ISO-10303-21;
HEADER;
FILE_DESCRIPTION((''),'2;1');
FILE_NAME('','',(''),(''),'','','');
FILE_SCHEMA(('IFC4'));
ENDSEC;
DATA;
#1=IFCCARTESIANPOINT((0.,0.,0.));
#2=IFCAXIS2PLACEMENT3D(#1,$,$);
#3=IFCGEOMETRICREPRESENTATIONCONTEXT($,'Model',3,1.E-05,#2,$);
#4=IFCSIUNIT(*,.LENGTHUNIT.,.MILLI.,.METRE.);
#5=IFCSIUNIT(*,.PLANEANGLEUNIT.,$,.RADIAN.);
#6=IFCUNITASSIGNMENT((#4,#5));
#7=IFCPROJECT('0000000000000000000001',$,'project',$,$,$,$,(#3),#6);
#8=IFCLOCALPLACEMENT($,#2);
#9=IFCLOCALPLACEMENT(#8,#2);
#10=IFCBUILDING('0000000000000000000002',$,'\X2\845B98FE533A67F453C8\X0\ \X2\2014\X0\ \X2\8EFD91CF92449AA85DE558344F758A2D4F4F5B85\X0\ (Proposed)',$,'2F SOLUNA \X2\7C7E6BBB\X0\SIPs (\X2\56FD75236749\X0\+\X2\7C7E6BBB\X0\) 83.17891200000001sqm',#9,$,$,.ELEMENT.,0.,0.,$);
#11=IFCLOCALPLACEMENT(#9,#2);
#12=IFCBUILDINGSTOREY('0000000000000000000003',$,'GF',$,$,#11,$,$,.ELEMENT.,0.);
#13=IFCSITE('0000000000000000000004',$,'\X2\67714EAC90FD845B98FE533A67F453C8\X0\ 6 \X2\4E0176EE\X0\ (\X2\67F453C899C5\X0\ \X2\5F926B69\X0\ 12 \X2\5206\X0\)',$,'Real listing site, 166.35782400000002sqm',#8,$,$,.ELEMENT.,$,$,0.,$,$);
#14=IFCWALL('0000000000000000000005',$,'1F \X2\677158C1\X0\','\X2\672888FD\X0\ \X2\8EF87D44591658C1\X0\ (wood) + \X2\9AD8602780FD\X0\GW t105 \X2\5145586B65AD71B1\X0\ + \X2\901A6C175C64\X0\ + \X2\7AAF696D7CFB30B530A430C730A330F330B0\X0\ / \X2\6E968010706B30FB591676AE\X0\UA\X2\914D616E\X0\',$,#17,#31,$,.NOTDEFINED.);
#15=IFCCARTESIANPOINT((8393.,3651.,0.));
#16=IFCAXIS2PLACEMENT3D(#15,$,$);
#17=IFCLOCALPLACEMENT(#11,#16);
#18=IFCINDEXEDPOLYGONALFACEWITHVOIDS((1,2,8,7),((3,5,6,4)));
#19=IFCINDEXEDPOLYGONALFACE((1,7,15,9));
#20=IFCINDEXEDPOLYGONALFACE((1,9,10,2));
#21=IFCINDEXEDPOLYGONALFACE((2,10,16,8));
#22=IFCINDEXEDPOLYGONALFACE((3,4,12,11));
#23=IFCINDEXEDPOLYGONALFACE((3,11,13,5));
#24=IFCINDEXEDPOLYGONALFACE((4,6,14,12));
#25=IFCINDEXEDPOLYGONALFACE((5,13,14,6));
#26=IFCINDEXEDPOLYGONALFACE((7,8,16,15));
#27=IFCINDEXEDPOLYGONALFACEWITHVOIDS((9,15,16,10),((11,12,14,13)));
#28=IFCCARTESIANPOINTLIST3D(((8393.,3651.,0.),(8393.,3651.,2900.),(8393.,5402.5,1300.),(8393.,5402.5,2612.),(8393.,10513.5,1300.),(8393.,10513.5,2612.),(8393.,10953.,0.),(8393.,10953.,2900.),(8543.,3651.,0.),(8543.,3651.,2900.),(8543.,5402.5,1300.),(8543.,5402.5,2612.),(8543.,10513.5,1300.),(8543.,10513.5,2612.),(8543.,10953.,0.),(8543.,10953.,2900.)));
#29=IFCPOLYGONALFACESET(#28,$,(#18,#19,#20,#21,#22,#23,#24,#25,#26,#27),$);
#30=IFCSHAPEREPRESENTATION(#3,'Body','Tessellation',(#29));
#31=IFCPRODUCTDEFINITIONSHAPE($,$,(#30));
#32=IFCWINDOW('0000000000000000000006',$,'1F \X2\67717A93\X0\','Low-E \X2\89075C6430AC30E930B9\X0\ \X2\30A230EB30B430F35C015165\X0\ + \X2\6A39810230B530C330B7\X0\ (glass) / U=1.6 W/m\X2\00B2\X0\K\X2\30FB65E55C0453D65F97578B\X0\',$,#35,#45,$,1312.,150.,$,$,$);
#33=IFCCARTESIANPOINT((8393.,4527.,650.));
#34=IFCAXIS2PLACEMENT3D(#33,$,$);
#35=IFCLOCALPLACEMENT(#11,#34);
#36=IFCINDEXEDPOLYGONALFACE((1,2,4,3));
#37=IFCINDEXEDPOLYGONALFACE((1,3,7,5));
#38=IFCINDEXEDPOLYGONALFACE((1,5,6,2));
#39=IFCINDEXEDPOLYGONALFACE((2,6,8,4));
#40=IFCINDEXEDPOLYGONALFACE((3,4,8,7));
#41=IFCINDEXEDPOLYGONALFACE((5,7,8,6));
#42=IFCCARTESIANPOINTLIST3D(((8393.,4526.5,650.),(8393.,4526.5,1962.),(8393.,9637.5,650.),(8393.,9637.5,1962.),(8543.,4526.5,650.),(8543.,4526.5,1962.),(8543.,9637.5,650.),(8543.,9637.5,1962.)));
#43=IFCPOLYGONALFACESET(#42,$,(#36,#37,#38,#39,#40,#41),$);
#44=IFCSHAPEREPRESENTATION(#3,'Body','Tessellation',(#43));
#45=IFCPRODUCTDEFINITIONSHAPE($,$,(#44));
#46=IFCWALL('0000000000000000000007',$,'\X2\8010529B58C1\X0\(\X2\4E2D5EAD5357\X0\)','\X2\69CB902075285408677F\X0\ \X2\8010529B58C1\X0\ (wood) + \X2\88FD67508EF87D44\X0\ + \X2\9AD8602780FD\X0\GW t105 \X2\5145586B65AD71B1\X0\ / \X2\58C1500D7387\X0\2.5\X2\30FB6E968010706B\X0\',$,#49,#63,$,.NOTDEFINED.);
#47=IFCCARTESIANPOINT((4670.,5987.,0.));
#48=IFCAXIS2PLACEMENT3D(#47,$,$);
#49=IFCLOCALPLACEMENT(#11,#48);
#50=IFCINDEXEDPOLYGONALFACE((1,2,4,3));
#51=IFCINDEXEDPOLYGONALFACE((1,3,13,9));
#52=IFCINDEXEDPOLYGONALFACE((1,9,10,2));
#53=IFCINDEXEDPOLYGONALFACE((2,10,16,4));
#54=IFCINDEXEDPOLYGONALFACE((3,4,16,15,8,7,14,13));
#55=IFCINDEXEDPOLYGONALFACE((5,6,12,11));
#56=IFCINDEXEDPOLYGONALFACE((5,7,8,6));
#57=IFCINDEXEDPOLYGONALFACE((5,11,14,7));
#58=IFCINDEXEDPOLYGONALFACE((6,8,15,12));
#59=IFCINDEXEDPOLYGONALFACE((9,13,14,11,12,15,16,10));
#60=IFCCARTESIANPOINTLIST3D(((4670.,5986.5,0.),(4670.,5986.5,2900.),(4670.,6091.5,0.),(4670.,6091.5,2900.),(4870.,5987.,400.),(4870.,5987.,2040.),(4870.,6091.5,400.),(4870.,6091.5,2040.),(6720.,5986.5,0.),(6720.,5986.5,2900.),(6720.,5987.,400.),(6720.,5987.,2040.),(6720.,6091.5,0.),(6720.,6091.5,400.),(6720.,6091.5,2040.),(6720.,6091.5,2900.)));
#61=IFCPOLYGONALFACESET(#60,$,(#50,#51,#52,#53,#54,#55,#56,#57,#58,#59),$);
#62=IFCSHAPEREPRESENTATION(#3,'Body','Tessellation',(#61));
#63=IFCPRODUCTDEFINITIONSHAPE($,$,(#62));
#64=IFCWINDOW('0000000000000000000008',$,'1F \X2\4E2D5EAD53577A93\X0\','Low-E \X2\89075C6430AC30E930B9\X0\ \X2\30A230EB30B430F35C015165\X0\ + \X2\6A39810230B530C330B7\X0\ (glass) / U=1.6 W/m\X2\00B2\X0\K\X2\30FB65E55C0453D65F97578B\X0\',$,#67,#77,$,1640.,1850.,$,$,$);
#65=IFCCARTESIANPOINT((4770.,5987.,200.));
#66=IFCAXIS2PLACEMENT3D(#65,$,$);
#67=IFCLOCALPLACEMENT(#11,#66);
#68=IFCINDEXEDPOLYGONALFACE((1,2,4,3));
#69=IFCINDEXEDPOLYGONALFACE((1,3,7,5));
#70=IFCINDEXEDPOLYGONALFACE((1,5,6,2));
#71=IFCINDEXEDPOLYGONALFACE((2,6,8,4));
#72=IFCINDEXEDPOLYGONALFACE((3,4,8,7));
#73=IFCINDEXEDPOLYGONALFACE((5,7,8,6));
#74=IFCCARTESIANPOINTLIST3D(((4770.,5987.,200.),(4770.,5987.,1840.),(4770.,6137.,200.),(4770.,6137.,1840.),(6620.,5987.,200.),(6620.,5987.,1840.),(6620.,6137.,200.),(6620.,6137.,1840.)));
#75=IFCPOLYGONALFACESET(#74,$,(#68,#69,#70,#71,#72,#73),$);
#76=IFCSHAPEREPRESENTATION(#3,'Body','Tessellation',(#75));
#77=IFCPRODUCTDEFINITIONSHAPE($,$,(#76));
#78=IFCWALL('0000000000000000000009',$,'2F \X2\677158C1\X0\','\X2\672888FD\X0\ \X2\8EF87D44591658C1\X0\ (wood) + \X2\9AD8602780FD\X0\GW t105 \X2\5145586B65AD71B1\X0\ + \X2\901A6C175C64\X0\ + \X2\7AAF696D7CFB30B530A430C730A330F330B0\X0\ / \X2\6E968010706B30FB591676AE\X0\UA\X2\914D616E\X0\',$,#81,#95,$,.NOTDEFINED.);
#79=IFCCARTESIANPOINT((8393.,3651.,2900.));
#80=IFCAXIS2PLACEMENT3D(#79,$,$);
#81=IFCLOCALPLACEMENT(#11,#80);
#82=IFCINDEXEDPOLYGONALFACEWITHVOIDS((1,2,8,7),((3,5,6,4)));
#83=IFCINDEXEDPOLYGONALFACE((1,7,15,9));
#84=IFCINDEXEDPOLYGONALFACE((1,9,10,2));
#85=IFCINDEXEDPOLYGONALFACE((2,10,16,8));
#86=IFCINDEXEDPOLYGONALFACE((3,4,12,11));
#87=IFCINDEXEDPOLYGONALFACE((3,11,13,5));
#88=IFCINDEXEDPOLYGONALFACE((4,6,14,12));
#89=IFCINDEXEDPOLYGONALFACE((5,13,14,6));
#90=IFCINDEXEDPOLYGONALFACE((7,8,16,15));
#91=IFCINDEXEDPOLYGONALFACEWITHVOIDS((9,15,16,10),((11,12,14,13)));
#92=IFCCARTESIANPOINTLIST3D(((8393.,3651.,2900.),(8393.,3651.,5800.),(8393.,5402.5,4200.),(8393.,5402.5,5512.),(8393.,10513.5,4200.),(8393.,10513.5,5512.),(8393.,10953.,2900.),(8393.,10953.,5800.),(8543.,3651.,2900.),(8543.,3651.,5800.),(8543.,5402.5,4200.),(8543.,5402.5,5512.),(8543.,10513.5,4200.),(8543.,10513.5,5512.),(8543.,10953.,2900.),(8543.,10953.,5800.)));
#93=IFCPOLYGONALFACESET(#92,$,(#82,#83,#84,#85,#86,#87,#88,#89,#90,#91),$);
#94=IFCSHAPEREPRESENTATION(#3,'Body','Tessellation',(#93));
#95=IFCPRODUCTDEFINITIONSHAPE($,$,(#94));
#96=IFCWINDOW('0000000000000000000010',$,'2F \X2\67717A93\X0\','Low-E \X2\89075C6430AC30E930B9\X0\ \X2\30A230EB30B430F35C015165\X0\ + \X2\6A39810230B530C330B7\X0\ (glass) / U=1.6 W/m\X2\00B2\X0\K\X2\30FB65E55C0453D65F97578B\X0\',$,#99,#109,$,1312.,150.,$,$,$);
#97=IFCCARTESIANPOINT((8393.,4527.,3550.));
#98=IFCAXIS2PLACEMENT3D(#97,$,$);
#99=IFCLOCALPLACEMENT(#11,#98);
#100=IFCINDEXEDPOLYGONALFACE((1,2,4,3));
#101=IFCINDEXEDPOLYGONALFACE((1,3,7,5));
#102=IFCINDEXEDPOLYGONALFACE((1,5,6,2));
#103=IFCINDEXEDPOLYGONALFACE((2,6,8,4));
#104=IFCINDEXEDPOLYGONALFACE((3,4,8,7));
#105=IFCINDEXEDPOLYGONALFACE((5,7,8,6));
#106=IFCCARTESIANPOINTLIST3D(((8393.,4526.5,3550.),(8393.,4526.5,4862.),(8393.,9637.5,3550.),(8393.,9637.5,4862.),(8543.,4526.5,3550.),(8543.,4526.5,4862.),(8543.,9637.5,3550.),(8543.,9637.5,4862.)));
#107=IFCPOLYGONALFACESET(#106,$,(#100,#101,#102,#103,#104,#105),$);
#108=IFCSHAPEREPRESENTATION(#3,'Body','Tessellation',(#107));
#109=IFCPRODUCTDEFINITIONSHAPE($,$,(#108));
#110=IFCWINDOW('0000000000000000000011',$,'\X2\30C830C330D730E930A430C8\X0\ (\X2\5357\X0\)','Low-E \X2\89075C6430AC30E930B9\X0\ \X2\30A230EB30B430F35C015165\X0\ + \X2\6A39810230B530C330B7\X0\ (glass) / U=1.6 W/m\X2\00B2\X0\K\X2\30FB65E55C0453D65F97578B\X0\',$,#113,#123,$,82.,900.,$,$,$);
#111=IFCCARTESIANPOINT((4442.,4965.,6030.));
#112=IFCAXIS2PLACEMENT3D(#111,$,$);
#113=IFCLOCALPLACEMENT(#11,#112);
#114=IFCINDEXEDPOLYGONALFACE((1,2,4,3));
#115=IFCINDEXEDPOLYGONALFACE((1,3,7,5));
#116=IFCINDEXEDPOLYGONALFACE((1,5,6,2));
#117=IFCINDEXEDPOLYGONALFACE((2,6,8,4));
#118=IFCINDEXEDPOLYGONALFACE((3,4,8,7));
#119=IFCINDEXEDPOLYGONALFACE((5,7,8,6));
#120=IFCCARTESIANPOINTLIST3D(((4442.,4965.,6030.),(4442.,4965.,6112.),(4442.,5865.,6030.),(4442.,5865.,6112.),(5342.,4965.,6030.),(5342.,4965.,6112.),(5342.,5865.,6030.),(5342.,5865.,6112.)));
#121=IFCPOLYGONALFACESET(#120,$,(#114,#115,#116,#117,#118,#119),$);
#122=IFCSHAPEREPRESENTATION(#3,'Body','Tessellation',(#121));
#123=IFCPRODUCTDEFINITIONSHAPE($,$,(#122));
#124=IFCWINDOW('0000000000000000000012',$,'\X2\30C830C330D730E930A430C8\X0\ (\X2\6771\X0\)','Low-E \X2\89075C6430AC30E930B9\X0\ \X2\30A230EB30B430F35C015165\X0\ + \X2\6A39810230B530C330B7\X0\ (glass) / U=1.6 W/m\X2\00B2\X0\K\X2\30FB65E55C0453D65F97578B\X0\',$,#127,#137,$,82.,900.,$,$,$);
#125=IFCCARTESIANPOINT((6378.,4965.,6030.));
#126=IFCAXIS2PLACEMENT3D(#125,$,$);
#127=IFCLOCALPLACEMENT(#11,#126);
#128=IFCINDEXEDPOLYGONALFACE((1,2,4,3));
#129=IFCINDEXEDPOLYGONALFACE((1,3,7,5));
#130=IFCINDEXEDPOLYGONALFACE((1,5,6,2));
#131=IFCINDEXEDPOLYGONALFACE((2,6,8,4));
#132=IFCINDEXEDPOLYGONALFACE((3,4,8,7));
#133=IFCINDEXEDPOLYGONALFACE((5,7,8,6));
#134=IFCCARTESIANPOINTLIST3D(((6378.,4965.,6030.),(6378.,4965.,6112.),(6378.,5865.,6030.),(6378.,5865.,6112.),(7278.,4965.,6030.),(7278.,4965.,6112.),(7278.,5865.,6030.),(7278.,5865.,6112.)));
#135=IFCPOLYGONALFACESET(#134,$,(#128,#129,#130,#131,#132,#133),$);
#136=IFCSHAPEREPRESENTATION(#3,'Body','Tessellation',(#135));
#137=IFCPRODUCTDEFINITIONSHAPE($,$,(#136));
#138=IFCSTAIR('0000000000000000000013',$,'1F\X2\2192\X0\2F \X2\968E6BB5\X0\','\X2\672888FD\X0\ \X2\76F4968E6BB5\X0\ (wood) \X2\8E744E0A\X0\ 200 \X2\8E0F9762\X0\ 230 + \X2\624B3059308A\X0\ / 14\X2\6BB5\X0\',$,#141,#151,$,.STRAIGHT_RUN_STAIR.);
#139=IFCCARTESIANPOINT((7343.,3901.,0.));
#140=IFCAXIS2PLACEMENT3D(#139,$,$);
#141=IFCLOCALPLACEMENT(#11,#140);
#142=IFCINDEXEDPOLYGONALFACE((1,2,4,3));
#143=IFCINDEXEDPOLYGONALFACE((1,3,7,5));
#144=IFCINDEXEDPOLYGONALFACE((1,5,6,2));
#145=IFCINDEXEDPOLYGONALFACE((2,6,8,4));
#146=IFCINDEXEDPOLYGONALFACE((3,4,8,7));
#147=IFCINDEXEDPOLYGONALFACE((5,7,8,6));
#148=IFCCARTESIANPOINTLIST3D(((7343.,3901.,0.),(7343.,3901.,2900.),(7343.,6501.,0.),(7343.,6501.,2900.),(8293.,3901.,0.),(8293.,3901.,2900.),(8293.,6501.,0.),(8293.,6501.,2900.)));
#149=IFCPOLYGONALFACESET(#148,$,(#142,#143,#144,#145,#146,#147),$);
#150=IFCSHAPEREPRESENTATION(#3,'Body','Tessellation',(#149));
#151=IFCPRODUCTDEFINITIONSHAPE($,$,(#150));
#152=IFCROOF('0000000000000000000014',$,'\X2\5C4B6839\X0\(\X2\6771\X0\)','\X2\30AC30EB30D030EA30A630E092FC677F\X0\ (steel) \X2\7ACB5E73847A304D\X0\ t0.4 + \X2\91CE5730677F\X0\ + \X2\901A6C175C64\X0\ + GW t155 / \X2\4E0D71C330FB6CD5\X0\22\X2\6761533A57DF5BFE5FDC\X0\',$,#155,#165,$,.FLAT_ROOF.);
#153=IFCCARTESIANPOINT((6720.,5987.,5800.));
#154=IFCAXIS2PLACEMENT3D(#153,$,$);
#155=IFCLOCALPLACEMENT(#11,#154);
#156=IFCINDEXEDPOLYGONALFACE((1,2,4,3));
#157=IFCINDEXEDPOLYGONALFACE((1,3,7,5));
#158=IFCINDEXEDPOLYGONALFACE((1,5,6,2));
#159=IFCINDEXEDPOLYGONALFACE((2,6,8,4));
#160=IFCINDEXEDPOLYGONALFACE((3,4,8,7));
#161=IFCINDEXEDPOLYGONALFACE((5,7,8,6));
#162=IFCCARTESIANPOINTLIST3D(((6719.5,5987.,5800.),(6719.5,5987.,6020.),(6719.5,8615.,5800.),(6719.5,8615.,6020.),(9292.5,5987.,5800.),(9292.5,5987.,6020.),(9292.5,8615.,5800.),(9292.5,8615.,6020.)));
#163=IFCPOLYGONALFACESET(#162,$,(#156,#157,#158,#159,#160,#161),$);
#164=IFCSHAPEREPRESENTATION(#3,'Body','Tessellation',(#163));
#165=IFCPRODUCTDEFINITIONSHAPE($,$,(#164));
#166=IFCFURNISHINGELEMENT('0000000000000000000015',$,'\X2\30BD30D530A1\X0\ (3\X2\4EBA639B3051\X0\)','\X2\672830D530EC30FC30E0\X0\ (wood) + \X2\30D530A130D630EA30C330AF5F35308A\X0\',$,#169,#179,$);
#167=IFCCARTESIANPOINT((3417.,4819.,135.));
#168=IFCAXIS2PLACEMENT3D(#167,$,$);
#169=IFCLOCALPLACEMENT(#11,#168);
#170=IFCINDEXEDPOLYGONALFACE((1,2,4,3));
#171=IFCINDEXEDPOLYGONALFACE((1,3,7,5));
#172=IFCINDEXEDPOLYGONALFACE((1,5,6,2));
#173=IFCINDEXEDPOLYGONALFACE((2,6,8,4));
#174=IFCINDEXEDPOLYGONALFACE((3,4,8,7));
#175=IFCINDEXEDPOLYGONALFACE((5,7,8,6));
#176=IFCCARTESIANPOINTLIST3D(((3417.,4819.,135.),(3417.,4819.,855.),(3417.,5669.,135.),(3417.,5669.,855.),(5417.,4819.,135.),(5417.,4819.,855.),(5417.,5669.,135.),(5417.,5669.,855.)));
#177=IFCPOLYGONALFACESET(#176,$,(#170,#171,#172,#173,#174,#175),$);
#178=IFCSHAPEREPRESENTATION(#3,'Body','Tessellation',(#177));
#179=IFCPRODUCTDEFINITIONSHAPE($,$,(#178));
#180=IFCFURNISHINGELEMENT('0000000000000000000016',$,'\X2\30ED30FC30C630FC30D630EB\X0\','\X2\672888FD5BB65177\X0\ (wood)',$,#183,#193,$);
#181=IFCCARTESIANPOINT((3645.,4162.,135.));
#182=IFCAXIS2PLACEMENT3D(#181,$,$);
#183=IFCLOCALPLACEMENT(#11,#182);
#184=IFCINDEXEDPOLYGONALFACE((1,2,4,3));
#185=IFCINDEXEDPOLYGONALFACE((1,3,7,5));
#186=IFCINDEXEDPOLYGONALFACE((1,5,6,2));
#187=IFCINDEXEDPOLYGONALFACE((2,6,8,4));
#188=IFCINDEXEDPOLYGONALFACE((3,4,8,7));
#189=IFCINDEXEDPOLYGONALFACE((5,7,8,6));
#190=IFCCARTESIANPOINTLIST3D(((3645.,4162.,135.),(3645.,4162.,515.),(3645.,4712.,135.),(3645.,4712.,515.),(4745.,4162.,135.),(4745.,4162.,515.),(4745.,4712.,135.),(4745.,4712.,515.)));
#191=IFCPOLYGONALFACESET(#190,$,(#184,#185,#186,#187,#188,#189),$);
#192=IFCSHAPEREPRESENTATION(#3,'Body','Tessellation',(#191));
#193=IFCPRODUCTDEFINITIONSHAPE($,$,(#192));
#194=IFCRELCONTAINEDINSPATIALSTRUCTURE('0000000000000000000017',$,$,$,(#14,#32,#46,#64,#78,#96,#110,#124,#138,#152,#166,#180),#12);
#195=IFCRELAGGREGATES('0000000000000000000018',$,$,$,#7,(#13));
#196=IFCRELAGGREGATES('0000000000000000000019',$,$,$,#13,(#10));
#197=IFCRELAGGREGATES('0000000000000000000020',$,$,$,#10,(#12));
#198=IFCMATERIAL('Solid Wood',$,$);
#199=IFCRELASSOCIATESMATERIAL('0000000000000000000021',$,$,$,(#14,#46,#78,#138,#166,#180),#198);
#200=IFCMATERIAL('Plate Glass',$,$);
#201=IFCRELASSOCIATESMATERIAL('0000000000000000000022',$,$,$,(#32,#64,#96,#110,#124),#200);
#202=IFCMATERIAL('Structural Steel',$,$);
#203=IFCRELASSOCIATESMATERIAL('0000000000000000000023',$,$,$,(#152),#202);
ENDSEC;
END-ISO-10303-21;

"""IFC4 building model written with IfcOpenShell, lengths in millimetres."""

from ifc_helpers import new_model, si_unit, frame, frame_2d, origin, place, context, project, spatial, rectangle, extrude, material, element, fill, save


model = new_model("IFC4")

# Units and contexts
model_context = context("Model", 3, precision=1e-05, world=origin())
ifc_project = project(units=[si_unit("LENGTHUNIT", "METRE", prefix="MILLI"), si_unit("PLANEANGLEUNIT", "RADIAN")], contexts=[model_context])

# Site, building, storey
site_placement = place(None, origin())
site = spatial("IfcSite", under=ifc_project, at=site_placement, Name="東京都葛飾区柴又 6 丁目 (柴又駅 徒歩 12 分)", ObjectType="Real listing site, 166.35782400000002sqm", CompositionType="ELEMENT", RefElevation=0.0)
building_placement = place(site_placement, origin())
building = spatial("IfcBuilding", under=site, at=building_placement, Name="葛飾区柴又 — 軽量鉄骨工場併設住宅 (Proposed)", ObjectType="2F SOLUNA 籾殻SIPs (国産杉+籾殻) 83.17891200000001sqm", CompositionType="ELEMENT", ElevationOfRefHeight=0.0, ElevationOfTerrain=0.0)
storey_placement = place(building_placement, origin())
storey = spatial("IfcBuildingStorey", under=building, at=storey_placement, Name="GF", CompositionType="ELEMENT", Elevation=0.0)

# Shared definitions
ifc_material_1 = material(Name="Solid Wood")

# Walls, openings, windows
wall_1_placement = place(storey_placement, frame((8393.0, 3651.0, 0.0)))
wall_1 = element("IfcWall", 1, at=wall_1_placement, inside=storey, material=ifc_material_1, Name="1F 東壁", Description="木製 軸組外壁 (wood) + 高性能GW t105 充填断熱 + 通気層 + 窯業系サイディング / 準耐火・外皮UA配慮", PredefinedType="NOTDEFINED", context=model_context, shape_type="SweptSolid", body=[
    extrude(rectangle(XDim=150.0, YDim=7302.0, at=frame_2d((75.0, 3651.0))), frame((8393.0, 3651.0, 0.0)), (0.0, 0.0, 1.0), 2900.0),
])
opening_1_placement = place(storey_placement, frame((8393.0, 4527.0, 650.0)))
opening_1 = element("IfcOpeningElement", 2, at=opening_1_placement, cuts=wall_1, PredefinedType="NOTDEFINED", context=model_context, shape_type="SweptSolid", body=[
    extrude(rectangle(XDim=150.0, YDim=5111.0, at=frame_2d((75.0, 2555.0))), frame((8393.0, 4527.0, 650.0)), (0.0, 0.0, 1.0), 1312.0),
])
ifc_material_2 = material(Name="Plate Glass")
window_1_placement = place(storey_placement, frame((8393.0, 4527.0, 650.0)))
window_1 = element("IfcWindow", 3, at=window_1_placement, inside=storey, material=ifc_material_2, Name="1F 東窓", Description="Low-E 複層ガラス アルゴン封入 + 樹脂サッシ (glass) / U=1.6 W/m²K・日射取得型", OverallHeight=1312.0, OverallWidth=150.0, context=model_context, shape_type="SweptSolid", body=[
    extrude(rectangle(XDim=150.0, YDim=5111.0, at=frame_2d((75.0, 2555.0))), frame((8393.0, 4527.0, 650.0)), (0.0, 0.0, 1.0), 1312.0),
])
fill(opening_1, window_1)
wall_2_placement = place(storey_placement, frame((4670.0, 5987.0, 0.0)))
wall_2 = element("IfcWall", 4, at=wall_2_placement, inside=storey, material=ifc_material_1, Name="耐力壁(中庭南)", Description="構造用合板 耐力壁 (wood) + 製材軸組 + 高性能GW t105 充填断熱 / 壁倍率2.5・準耐火", PredefinedType="NOTDEFINED", context=model_context, shape_type="SweptSolid", body=[
    extrude(rectangle(XDim=2050.0, YDim=105.0, at=frame_2d((1025.0, 52.0))), frame((4670.0, 5987.0, 0.0)), (0.0, 0.0, 1.0), 2900.0),
])
opening_2_placement = place(storey_placement, frame((4770.0, 5987.0, 200.0)))
opening_2 = element("IfcOpeningElement", 5, at=opening_2_placement, cuts=wall_2, PredefinedType="NOTDEFINED", context=model_context, shape_type="SweptSolid", body=[
    extrude(rectangle(XDim=1850.0, YDim=150.0, at=frame_2d((925.0, 75.0))), frame((4770.0, 5987.0, 200.0)), (0.0, 0.0, 1.0), 1640.0),
])
window_2_placement = place(storey_placement, frame((4770.0, 5987.0, 200.0)))
window_2 = element("IfcWindow", 6, at=window_2_placement, inside=storey, material=ifc_material_2, Name="1F 中庭南窓", Description="Low-E 複層ガラス アルゴン封入 + 樹脂サッシ (glass) / U=1.6 W/m²K・日射取得型", OverallHeight=1640.0, OverallWidth=1850.0, context=model_context, shape_type="SweptSolid", body=[
    extrude(rectangle(XDim=1850.0, YDim=150.0, at=frame_2d((925.0, 75.0))), frame((4770.0, 5987.0, 200.0)), (0.0, 0.0, 1.0), 1640.0),
])
fill(opening_2, window_2)

# Wall, opening, window
wall_3_placement = place(storey_placement, frame((8393.0, 3651.0, 2900.0)))
wall_3 = element("IfcWall", 7, at=wall_3_placement, inside=storey, material=ifc_material_1, Name="2F 東壁", Description="木製 軸組外壁 (wood) + 高性能GW t105 充填断熱 + 通気層 + 窯業系サイディング / 準耐火・外皮UA配慮", PredefinedType="NOTDEFINED", context=model_context, shape_type="SweptSolid", body=[
    extrude(rectangle(XDim=150.0, YDim=7302.0, at=frame_2d((75.0, 3651.0))), frame((8393.0, 3651.0, 2900.0)), (0.0, 0.0, 1.0), 2900.0),
])
opening_3_placement = place(storey_placement, frame((8393.0, 4527.0, 3550.0)))
opening_3 = element("IfcOpeningElement", 8, at=opening_3_placement, cuts=wall_3, PredefinedType="NOTDEFINED", context=model_context, shape_type="SweptSolid", body=[
    extrude(rectangle(XDim=150.0, YDim=5111.0, at=frame_2d((75.0, 2555.0))), frame((8393.0, 4527.0, 3550.0)), (0.0, 0.0, 1.0), 1312.0),
])
window_3_placement = place(storey_placement, frame((8393.0, 4527.0, 3550.0)))
window_3 = element("IfcWindow", 9, at=window_3_placement, inside=storey, material=ifc_material_2, Name="2F 東窓", Description="Low-E 複層ガラス アルゴン封入 + 樹脂サッシ (glass) / U=1.6 W/m²K・日射取得型", OverallHeight=1312.0, OverallWidth=150.0, context=model_context, shape_type="SweptSolid", body=[
    extrude(rectangle(XDim=150.0, YDim=5111.0, at=frame_2d((75.0, 2555.0))), frame((8393.0, 4527.0, 3550.0)), (0.0, 0.0, 1.0), 1312.0),
])
fill(opening_3, window_3)

# Windows
window_4_placement = place(storey_placement, frame((4442.0, 4965.0, 6030.0)))
element("IfcWindow", 10, at=window_4_placement, inside=storey, material=ifc_material_2, Name="トップライト (南)", Description="Low-E 複層ガラス アルゴン封入 + 樹脂サッシ (glass) / U=1.6 W/m²K・日射取得型", OverallHeight=82.0, OverallWidth=900.0, context=model_context, shape_type="SweptSolid", body=[
    extrude(rectangle(XDim=900.0, YDim=900.0, at=frame_2d((450.0, 450.0))), frame((4442.0, 4965.0, 6030.0)), (0.0, 0.0, 1.0), 82.0),
])
window_5_placement = place(storey_placement, frame((6378.0, 4965.0, 6030.0)))
element("IfcWindow", 11, at=window_5_placement, inside=storey, material=ifc_material_2, Name="トップライト (東)", Description="Low-E 複層ガラス アルゴン封入 + 樹脂サッシ (glass) / U=1.6 W/m²K・日射取得型", OverallHeight=82.0, OverallWidth=900.0, context=model_context, shape_type="SweptSolid", body=[
    extrude(rectangle(XDim=900.0, YDim=900.0, at=frame_2d((450.0, 450.0))), frame((6378.0, 4965.0, 6030.0)), (0.0, 0.0, 1.0), 82.0),
])

# Stair
stair_placement = place(storey_placement, frame((7343.0, 3901.0, 0.0)))
element("IfcStair", 12, at=stair_placement, inside=storey, material=ifc_material_1, Name="1F→2F 階段", Description="木製 直階段 (wood) 蹴上 200 踏面 230 + 手すり / 14段", PredefinedType="STRAIGHT_RUN_STAIR", context=model_context, shape_type="SweptSolid", body=[
    extrude(rectangle(XDim=950.0, YDim=2600.0, at=frame_2d((475.0, 1300.0))), frame((7343.0, 3901.0, 0.0)), (0.0, 0.0, 1.0), 2900.0),
])

# Roof
ifc_material_3 = material(Name="Structural Steel")
roof_placement = place(storey_placement, frame((6720.0, 5987.0, 5800.0)))
element("IfcRoof", 13, at=roof_placement, inside=storey, material=ifc_material_3, Name="屋根(東)", Description="ガルバリウム鋼板 (steel) 立平葺き t0.4 + 野地板 + 通気層 + GW t155 / 不燃・法22条区域対応", PredefinedType="FLAT_ROOF", context=model_context, shape_type="SweptSolid", body=[
    extrude(rectangle(XDim=2573.0, YDim=2628.0, at=frame_2d((1286.0, 1314.0))), frame((6720.0, 5987.0, 5800.0)), (0.0, 0.0, 1.0), 220.0),
])

# Furnishing elements
furnishing_1_placement = place(storey_placement, frame((3417.0, 4819.0, 135.0)))
element("IfcFurnishingElement", 14, at=furnishing_1_placement, inside=storey, material=ifc_material_1, Name="ソファ (3人掛け)", Description="木フレーム (wood) + ファブリック張り", context=model_context, shape_type="SweptSolid", body=[
    extrude(rectangle(XDim=2000.0, YDim=850.0, at=frame_2d((1000.0, 425.0))), frame((3417.0, 4819.0, 135.0)), (0.0, 0.0, 1.0), 720.0),
])
furnishing_2_placement = place(storey_placement, frame((3645.0, 4162.0, 135.0)))
element("IfcFurnishingElement", 15, at=furnishing_2_placement, inside=storey, material=ifc_material_1, Name="ローテーブル", Description="木製家具 (wood)", context=model_context, shape_type="SweptSolid", body=[
    extrude(rectangle(XDim=1100.0, YDim=550.0, at=frame_2d((550.0, 275.0))), frame((3645.0, 4162.0, 135.0)), (0.0, 0.0, 1.0), 380.0),
])

save(model, "model.ifc")
